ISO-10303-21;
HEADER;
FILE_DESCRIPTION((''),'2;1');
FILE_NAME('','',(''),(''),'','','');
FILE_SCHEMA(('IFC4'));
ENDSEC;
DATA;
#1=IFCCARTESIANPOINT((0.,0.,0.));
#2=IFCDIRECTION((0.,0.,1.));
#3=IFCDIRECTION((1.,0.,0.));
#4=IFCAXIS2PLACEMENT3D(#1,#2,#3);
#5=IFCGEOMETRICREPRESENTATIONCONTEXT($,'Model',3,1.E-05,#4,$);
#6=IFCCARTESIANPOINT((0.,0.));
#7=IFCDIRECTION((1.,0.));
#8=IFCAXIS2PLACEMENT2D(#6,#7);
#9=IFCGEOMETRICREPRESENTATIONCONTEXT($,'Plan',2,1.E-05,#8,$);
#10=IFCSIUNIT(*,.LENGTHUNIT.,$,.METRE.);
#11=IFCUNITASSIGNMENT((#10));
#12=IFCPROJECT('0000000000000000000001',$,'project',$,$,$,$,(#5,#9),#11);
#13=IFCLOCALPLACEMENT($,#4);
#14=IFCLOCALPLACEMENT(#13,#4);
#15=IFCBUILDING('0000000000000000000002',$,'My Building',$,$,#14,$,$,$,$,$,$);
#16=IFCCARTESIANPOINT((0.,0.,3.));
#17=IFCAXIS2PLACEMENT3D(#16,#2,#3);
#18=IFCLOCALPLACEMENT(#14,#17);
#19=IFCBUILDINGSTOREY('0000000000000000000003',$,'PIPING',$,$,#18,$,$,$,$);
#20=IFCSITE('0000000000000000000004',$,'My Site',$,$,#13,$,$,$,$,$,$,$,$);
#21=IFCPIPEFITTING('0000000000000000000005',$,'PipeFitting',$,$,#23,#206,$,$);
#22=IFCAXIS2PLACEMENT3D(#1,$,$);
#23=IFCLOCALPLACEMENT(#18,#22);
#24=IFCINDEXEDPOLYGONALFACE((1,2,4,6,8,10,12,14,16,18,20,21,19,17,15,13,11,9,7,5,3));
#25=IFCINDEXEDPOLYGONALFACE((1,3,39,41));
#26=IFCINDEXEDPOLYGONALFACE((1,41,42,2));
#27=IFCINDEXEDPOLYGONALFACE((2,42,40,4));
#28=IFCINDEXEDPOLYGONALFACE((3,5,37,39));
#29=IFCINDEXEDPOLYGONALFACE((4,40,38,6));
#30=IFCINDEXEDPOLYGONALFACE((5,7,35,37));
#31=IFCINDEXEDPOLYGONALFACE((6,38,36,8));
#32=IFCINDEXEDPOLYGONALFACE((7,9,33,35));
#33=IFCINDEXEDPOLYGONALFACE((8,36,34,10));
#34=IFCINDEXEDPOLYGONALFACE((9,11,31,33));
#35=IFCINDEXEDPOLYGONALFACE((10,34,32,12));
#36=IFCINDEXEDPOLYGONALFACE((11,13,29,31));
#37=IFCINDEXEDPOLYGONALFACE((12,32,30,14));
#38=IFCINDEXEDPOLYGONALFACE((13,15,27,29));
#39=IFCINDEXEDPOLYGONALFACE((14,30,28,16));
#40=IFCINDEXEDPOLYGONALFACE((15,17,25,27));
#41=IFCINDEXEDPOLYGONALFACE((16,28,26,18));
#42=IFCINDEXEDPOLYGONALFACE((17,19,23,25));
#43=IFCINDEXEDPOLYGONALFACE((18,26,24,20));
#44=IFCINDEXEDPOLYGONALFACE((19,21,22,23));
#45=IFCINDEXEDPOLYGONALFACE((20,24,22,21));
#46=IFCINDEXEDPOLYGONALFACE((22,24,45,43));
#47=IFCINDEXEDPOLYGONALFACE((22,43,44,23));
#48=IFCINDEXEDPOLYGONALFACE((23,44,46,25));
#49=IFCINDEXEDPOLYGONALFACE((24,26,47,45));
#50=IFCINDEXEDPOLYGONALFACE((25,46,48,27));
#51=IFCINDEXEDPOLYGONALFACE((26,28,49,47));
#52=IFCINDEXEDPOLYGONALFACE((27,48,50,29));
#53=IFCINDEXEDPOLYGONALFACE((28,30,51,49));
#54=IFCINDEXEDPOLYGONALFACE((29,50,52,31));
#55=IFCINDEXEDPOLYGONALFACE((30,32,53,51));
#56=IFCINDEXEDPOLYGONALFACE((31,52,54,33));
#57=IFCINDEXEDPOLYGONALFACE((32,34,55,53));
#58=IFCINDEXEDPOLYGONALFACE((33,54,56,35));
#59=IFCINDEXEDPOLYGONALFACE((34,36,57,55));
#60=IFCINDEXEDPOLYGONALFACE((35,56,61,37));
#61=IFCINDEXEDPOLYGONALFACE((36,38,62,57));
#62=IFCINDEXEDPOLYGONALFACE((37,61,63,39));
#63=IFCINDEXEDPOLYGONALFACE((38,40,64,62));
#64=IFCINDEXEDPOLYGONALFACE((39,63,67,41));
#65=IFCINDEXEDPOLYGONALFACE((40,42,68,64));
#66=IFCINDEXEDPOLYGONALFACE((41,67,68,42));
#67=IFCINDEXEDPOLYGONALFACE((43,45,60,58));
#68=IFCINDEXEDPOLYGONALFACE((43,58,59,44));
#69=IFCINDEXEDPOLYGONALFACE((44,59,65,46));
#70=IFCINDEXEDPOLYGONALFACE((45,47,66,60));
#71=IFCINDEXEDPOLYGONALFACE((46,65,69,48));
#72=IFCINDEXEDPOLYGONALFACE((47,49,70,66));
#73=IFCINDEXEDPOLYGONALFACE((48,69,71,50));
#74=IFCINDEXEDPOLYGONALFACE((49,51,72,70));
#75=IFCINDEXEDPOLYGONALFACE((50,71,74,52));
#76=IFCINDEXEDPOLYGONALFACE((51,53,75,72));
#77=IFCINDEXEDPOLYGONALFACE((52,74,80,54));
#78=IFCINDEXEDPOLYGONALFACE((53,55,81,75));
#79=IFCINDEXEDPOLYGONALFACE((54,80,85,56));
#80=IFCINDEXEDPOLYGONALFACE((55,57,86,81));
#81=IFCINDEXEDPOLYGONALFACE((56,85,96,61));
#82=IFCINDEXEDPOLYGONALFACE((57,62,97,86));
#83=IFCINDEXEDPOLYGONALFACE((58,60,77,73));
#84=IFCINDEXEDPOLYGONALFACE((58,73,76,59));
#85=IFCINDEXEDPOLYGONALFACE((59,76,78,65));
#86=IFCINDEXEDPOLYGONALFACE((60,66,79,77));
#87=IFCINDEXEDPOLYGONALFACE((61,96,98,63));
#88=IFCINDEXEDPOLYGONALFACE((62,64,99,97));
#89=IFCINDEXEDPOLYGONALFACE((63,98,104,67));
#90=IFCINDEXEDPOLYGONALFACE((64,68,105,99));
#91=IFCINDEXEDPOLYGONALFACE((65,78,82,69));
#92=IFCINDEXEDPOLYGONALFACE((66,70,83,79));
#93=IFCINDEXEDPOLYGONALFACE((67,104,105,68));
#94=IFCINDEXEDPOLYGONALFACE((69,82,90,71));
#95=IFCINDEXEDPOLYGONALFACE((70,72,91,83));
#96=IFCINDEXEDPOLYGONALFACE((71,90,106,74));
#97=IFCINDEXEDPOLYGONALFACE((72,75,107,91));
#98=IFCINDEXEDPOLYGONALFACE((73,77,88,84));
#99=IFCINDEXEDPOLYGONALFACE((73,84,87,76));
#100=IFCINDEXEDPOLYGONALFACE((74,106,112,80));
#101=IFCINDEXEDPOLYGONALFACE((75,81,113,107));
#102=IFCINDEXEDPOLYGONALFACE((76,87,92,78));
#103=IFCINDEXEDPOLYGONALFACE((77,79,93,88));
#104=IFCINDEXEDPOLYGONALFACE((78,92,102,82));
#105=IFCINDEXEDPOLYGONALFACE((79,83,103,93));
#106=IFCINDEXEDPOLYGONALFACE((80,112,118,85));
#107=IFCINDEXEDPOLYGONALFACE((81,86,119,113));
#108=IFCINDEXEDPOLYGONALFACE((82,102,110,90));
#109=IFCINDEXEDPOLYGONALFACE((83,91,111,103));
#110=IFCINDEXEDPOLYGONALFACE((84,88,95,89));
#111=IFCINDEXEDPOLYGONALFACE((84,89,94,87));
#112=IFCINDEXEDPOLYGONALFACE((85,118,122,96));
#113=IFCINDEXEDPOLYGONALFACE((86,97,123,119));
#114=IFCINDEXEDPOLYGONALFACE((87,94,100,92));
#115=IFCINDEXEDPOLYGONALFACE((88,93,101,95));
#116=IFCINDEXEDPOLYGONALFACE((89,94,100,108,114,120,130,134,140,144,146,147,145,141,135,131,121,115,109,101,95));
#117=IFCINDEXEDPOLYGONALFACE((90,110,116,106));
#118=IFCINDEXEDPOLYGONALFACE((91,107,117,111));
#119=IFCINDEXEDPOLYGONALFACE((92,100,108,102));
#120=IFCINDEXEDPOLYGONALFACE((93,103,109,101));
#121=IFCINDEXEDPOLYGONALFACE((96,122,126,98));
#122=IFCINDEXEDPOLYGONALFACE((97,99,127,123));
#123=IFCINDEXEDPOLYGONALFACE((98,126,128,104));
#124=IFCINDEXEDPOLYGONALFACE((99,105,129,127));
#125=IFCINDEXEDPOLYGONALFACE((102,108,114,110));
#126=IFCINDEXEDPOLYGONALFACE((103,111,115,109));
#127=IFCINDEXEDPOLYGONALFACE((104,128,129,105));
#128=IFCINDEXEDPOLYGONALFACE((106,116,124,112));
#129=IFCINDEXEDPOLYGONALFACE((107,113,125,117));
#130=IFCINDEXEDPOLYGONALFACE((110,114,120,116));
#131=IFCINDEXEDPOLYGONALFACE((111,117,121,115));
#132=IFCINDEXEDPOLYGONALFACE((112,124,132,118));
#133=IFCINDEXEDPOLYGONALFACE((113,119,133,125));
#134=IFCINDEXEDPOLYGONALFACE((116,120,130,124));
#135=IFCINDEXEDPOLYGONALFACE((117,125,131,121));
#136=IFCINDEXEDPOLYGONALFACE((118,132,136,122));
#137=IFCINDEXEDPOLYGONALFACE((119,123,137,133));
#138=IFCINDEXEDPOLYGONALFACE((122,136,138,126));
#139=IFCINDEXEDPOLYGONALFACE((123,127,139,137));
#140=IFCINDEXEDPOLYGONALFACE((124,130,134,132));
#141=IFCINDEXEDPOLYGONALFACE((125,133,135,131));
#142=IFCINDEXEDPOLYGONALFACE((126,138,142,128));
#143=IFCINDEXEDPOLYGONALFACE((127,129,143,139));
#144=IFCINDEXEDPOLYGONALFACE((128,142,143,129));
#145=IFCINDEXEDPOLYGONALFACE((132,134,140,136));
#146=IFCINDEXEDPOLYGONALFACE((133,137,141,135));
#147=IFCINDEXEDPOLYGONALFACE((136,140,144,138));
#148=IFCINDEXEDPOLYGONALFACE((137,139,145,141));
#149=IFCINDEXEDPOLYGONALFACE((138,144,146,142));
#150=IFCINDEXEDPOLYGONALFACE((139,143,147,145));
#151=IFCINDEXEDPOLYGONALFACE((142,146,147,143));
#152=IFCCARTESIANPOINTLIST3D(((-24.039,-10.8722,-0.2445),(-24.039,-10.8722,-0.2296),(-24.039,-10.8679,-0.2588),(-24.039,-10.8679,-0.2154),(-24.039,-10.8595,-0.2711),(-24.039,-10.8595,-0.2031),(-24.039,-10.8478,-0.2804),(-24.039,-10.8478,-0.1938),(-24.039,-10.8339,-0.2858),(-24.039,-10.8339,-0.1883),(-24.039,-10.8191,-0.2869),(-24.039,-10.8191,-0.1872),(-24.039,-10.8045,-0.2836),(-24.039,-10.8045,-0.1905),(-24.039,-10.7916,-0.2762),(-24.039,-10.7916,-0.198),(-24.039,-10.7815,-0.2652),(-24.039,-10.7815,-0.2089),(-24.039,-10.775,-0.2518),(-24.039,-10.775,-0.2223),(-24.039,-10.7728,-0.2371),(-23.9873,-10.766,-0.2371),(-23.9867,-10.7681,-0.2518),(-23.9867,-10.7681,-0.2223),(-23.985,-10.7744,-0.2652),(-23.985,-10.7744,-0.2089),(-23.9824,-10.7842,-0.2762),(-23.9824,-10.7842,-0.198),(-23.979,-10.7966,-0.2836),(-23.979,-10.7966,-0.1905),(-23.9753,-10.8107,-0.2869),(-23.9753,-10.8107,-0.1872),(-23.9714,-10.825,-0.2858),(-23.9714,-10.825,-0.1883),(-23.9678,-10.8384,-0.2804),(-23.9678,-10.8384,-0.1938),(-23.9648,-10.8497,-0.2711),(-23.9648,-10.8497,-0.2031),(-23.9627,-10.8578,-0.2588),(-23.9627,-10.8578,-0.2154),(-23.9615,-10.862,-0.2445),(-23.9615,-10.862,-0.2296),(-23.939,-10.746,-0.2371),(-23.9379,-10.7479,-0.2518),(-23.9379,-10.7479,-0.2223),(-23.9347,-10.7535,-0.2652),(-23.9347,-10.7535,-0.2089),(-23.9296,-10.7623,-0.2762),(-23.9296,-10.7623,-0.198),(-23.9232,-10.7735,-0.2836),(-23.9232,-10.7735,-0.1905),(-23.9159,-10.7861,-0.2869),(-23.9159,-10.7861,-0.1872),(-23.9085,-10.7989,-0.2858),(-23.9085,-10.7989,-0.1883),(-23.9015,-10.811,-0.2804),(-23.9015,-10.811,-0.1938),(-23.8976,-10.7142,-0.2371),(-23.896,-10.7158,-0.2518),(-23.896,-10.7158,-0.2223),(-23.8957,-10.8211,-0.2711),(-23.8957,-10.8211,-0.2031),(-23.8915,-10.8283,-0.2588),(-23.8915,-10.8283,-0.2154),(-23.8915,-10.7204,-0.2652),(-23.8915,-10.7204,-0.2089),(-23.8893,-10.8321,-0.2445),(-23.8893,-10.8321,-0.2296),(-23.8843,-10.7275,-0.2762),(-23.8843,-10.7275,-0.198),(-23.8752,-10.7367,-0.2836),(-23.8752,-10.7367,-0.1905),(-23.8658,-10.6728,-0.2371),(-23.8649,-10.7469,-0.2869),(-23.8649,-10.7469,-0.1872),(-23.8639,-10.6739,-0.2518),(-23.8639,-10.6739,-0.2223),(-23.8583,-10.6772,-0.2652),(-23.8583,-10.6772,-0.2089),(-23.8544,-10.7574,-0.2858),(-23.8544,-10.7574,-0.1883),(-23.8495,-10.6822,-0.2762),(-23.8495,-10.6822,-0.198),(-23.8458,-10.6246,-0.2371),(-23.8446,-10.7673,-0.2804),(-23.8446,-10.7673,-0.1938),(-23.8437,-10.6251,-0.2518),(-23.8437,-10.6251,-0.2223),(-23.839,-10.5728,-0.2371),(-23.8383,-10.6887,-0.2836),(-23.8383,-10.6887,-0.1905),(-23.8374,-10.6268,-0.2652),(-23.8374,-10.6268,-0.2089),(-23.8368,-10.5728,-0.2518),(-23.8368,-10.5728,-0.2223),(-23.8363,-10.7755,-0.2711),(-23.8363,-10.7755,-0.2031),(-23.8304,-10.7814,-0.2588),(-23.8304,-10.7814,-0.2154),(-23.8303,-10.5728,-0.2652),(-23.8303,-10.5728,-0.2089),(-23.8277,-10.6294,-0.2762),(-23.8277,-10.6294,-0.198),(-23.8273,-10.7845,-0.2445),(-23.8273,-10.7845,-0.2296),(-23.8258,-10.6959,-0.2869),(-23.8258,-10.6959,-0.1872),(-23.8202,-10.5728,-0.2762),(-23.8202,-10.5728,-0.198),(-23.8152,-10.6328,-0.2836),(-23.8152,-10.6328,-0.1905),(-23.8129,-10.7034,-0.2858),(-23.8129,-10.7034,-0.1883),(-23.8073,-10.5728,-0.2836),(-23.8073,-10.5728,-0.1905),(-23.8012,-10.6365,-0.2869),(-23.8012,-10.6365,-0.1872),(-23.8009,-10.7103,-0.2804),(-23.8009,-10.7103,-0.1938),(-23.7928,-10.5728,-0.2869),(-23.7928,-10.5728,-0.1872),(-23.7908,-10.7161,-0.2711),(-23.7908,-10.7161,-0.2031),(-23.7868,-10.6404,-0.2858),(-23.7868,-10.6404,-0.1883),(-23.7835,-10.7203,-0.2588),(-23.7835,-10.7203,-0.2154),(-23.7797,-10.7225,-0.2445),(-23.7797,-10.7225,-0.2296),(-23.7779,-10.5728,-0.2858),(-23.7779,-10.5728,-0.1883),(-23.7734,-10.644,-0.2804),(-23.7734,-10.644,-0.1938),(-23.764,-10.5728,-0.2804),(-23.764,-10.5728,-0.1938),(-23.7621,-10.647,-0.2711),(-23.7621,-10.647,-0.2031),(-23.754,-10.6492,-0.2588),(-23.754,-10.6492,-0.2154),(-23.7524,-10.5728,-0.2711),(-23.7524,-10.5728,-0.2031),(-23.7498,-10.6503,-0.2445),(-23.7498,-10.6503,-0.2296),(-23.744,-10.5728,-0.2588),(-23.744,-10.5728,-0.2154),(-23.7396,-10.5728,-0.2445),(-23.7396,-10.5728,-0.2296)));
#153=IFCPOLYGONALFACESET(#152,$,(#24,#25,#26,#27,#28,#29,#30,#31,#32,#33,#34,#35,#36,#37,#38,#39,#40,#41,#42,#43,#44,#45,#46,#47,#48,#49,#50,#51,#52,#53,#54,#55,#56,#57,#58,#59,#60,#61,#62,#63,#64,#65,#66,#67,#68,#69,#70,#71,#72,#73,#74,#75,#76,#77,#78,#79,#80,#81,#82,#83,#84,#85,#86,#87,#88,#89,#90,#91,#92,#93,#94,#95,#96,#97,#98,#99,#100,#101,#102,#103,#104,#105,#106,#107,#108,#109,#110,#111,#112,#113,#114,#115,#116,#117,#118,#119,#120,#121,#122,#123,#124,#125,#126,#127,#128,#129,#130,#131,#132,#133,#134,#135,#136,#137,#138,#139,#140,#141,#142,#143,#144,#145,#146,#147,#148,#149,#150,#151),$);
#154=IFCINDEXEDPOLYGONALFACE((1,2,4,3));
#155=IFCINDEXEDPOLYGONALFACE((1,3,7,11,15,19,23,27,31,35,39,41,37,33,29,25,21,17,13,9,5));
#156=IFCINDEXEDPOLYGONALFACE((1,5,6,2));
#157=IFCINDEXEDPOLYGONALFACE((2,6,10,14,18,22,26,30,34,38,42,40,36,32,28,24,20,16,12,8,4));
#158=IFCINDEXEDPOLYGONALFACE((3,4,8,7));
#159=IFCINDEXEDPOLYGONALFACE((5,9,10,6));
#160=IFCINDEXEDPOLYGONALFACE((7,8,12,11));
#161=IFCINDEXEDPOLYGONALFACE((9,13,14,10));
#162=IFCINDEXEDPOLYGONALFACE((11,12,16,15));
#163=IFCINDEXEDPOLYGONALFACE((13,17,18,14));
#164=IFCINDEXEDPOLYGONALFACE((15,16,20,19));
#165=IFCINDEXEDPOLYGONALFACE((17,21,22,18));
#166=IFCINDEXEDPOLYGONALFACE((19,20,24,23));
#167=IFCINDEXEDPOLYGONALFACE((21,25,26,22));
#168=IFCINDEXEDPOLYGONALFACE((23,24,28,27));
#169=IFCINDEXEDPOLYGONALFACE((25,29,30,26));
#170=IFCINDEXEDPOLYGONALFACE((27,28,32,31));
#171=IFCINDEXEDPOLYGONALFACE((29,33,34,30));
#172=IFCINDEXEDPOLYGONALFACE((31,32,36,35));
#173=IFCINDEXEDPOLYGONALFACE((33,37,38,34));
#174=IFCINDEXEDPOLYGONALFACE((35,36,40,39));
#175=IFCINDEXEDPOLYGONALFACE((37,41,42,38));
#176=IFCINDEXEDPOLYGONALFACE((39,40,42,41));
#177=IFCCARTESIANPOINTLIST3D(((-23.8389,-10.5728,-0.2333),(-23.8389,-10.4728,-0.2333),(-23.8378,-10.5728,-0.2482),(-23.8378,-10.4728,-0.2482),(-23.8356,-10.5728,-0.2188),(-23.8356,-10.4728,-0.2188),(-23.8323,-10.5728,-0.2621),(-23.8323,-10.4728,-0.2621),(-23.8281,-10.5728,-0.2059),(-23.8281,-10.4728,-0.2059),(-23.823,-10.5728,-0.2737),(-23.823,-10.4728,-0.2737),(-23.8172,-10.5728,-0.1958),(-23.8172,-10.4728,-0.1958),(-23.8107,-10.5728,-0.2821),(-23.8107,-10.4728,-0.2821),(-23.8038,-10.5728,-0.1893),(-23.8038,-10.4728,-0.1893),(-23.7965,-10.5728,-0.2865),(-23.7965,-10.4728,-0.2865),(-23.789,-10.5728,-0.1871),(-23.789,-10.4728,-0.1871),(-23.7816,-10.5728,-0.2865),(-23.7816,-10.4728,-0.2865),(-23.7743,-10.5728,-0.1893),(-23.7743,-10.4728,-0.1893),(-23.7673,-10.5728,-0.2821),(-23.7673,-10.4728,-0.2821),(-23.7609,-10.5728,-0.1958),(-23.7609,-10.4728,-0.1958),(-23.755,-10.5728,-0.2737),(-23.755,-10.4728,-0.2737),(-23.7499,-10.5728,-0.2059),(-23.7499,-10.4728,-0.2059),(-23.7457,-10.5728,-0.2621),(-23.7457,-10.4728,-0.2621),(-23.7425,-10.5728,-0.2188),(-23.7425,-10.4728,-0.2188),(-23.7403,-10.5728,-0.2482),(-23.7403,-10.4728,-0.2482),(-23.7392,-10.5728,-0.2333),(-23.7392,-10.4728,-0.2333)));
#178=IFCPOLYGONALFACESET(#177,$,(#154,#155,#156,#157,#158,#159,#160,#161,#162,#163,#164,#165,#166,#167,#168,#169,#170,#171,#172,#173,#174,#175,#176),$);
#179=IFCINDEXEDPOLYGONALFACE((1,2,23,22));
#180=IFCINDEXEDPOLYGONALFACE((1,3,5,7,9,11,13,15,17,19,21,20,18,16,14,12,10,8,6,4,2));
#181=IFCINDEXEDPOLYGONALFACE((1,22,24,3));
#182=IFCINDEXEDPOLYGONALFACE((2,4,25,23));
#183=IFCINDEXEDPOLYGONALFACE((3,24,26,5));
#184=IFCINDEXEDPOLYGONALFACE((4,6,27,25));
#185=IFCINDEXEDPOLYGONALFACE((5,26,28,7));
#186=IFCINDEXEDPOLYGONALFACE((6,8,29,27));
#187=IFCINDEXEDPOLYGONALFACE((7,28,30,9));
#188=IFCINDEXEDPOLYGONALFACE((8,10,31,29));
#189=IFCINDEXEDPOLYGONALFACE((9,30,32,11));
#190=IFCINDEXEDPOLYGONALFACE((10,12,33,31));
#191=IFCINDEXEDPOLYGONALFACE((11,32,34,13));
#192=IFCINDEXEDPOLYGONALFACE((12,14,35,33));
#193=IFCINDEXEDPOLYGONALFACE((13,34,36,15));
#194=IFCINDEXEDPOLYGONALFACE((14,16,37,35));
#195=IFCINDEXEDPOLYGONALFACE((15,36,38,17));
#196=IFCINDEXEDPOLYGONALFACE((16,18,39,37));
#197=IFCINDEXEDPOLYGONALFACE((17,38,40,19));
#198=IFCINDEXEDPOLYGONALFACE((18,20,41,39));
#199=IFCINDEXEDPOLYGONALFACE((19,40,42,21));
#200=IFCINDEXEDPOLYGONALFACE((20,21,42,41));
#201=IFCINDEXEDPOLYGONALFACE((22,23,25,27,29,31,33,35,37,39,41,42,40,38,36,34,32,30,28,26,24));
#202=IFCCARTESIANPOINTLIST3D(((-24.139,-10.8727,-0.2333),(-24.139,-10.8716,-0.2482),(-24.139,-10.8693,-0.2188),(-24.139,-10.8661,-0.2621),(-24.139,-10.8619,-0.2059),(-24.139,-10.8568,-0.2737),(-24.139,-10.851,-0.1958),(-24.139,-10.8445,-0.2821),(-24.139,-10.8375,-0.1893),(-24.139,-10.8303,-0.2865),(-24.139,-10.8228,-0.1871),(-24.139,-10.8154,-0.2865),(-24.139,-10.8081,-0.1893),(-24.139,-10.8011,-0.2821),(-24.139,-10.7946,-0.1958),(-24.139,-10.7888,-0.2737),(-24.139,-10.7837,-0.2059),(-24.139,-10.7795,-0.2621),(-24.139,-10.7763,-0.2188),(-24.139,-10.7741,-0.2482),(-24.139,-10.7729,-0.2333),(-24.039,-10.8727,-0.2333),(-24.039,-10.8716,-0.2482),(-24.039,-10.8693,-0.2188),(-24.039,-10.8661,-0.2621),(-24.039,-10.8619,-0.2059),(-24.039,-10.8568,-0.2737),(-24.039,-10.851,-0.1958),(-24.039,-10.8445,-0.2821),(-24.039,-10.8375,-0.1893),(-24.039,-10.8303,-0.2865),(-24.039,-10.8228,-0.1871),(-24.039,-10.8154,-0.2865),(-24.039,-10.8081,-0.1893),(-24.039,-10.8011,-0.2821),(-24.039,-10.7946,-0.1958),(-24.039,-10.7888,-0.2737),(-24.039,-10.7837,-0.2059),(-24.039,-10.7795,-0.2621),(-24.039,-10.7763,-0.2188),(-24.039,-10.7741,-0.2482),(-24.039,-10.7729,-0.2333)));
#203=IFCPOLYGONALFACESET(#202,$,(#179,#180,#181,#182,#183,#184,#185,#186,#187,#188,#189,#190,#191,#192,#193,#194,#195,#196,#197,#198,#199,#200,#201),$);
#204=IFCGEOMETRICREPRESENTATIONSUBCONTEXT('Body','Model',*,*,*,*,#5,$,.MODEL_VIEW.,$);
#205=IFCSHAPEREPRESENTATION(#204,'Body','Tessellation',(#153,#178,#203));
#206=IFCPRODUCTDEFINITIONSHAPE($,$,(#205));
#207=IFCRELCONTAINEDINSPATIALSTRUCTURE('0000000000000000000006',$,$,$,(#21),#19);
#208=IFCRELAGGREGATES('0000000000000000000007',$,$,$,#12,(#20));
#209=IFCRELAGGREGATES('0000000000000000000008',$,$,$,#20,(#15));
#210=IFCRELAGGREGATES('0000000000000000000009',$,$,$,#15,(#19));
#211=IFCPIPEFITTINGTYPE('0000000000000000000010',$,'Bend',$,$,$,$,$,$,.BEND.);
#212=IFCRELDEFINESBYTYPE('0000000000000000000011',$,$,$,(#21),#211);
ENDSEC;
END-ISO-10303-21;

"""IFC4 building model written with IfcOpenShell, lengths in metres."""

from ifc_helpers import new_model, entity, si_unit, frame, origin_with_axes, origin_2d_with_axis, place, context, subcontext, project, spatial, circle, extrude, source, transform, mapped, type_object, type_shapes, element, save


model = new_model("IFC4")

# Units and contexts
model_context = context("Model", 3, precision=1e-05, world=origin_with_axes())
plan_context = context("Plan", 2, precision=1e-05, world=origin_2d_with_axis())
body_context = subcontext(model_context, "Body", "Model", "MODEL_VIEW")
ifc_project = project(units=[si_unit("LENGTHUNIT", "METRE")], contexts=[model_context, plan_context])

# Site, building, storey
site_placement = place(None, origin_with_axes())
site = spatial("IfcSite", under=ifc_project, at=site_placement, Name="My Site")
building_placement = place(site_placement, origin_with_axes())
building = spatial("IfcBuilding", under=site, at=building_placement, Name="My Building")
storey_placement = place(building_placement, frame((0.0, 0.0, 3.0), z_axis=(0.0, 0.0, 1.0), x_axis=(1.0, 0.0, 0.0)))
storey = spatial("IfcBuildingStorey", under=building, at=storey_placement, Name="PIPING")

# Pipe fitting
pipe_fitting_type = type_object("IfcPipeFittingType", Name="Bend", PredefinedType="BEND")
shared_shape = source(origin_with_axes(), body_context, "Body", "SolidModel", [
    entity("IfcSweptDiskSolid", entity("IfcIndexedPolyCurve", entity("IfcCartesianPointList3D", [[0.0, 0.0, -0.1], [0.0, -0.0732, -0.2768], [0.0, -0.25, -0.35]]), [entity("IfcArcIndex", [1, 2, 3])]), 0.05),
    extrude(circle(Radius=0.05), origin_with_axes(), (0.0, 0.0, -1.0), 0.1),
    extrude(circle(Radius=0.05), frame((0.0, -0.25, -0.35), z_axis=(0.0, -1.0, 0.0), x_axis=(1.0, 0.0, 0.0)), (0.0, 0.0, 1.0), 0.1),
])
type_shapes(pipe_fitting_type, [shared_shape])
for number, where, z_axis, x_axis, name in (
    (1, (-23.789, -10.4728, -0.2371), (0.0, 1.0, 0.0), (0.0, 0.0, 1.0), "PipeFitting"),
):
    element("IfcPipeFitting", number, at=place(storey_placement, frame(where, z_axis=z_axis, x_axis=x_axis)), inside=storey, type_object=pipe_fitting_type, Name=name, context=body_context, shape_type="MappedRepresentation", body=[
        mapped(shared_shape, transform((0.0, 0.0, 0.0), x_axis=(1.0, 0.0, 0.0), y_axis=(0.0, 1.0, 0.0), z_axis=(0.0, 0.0, 1.0), scale=1.0)),
    ])

save(model, "model.ifc")
